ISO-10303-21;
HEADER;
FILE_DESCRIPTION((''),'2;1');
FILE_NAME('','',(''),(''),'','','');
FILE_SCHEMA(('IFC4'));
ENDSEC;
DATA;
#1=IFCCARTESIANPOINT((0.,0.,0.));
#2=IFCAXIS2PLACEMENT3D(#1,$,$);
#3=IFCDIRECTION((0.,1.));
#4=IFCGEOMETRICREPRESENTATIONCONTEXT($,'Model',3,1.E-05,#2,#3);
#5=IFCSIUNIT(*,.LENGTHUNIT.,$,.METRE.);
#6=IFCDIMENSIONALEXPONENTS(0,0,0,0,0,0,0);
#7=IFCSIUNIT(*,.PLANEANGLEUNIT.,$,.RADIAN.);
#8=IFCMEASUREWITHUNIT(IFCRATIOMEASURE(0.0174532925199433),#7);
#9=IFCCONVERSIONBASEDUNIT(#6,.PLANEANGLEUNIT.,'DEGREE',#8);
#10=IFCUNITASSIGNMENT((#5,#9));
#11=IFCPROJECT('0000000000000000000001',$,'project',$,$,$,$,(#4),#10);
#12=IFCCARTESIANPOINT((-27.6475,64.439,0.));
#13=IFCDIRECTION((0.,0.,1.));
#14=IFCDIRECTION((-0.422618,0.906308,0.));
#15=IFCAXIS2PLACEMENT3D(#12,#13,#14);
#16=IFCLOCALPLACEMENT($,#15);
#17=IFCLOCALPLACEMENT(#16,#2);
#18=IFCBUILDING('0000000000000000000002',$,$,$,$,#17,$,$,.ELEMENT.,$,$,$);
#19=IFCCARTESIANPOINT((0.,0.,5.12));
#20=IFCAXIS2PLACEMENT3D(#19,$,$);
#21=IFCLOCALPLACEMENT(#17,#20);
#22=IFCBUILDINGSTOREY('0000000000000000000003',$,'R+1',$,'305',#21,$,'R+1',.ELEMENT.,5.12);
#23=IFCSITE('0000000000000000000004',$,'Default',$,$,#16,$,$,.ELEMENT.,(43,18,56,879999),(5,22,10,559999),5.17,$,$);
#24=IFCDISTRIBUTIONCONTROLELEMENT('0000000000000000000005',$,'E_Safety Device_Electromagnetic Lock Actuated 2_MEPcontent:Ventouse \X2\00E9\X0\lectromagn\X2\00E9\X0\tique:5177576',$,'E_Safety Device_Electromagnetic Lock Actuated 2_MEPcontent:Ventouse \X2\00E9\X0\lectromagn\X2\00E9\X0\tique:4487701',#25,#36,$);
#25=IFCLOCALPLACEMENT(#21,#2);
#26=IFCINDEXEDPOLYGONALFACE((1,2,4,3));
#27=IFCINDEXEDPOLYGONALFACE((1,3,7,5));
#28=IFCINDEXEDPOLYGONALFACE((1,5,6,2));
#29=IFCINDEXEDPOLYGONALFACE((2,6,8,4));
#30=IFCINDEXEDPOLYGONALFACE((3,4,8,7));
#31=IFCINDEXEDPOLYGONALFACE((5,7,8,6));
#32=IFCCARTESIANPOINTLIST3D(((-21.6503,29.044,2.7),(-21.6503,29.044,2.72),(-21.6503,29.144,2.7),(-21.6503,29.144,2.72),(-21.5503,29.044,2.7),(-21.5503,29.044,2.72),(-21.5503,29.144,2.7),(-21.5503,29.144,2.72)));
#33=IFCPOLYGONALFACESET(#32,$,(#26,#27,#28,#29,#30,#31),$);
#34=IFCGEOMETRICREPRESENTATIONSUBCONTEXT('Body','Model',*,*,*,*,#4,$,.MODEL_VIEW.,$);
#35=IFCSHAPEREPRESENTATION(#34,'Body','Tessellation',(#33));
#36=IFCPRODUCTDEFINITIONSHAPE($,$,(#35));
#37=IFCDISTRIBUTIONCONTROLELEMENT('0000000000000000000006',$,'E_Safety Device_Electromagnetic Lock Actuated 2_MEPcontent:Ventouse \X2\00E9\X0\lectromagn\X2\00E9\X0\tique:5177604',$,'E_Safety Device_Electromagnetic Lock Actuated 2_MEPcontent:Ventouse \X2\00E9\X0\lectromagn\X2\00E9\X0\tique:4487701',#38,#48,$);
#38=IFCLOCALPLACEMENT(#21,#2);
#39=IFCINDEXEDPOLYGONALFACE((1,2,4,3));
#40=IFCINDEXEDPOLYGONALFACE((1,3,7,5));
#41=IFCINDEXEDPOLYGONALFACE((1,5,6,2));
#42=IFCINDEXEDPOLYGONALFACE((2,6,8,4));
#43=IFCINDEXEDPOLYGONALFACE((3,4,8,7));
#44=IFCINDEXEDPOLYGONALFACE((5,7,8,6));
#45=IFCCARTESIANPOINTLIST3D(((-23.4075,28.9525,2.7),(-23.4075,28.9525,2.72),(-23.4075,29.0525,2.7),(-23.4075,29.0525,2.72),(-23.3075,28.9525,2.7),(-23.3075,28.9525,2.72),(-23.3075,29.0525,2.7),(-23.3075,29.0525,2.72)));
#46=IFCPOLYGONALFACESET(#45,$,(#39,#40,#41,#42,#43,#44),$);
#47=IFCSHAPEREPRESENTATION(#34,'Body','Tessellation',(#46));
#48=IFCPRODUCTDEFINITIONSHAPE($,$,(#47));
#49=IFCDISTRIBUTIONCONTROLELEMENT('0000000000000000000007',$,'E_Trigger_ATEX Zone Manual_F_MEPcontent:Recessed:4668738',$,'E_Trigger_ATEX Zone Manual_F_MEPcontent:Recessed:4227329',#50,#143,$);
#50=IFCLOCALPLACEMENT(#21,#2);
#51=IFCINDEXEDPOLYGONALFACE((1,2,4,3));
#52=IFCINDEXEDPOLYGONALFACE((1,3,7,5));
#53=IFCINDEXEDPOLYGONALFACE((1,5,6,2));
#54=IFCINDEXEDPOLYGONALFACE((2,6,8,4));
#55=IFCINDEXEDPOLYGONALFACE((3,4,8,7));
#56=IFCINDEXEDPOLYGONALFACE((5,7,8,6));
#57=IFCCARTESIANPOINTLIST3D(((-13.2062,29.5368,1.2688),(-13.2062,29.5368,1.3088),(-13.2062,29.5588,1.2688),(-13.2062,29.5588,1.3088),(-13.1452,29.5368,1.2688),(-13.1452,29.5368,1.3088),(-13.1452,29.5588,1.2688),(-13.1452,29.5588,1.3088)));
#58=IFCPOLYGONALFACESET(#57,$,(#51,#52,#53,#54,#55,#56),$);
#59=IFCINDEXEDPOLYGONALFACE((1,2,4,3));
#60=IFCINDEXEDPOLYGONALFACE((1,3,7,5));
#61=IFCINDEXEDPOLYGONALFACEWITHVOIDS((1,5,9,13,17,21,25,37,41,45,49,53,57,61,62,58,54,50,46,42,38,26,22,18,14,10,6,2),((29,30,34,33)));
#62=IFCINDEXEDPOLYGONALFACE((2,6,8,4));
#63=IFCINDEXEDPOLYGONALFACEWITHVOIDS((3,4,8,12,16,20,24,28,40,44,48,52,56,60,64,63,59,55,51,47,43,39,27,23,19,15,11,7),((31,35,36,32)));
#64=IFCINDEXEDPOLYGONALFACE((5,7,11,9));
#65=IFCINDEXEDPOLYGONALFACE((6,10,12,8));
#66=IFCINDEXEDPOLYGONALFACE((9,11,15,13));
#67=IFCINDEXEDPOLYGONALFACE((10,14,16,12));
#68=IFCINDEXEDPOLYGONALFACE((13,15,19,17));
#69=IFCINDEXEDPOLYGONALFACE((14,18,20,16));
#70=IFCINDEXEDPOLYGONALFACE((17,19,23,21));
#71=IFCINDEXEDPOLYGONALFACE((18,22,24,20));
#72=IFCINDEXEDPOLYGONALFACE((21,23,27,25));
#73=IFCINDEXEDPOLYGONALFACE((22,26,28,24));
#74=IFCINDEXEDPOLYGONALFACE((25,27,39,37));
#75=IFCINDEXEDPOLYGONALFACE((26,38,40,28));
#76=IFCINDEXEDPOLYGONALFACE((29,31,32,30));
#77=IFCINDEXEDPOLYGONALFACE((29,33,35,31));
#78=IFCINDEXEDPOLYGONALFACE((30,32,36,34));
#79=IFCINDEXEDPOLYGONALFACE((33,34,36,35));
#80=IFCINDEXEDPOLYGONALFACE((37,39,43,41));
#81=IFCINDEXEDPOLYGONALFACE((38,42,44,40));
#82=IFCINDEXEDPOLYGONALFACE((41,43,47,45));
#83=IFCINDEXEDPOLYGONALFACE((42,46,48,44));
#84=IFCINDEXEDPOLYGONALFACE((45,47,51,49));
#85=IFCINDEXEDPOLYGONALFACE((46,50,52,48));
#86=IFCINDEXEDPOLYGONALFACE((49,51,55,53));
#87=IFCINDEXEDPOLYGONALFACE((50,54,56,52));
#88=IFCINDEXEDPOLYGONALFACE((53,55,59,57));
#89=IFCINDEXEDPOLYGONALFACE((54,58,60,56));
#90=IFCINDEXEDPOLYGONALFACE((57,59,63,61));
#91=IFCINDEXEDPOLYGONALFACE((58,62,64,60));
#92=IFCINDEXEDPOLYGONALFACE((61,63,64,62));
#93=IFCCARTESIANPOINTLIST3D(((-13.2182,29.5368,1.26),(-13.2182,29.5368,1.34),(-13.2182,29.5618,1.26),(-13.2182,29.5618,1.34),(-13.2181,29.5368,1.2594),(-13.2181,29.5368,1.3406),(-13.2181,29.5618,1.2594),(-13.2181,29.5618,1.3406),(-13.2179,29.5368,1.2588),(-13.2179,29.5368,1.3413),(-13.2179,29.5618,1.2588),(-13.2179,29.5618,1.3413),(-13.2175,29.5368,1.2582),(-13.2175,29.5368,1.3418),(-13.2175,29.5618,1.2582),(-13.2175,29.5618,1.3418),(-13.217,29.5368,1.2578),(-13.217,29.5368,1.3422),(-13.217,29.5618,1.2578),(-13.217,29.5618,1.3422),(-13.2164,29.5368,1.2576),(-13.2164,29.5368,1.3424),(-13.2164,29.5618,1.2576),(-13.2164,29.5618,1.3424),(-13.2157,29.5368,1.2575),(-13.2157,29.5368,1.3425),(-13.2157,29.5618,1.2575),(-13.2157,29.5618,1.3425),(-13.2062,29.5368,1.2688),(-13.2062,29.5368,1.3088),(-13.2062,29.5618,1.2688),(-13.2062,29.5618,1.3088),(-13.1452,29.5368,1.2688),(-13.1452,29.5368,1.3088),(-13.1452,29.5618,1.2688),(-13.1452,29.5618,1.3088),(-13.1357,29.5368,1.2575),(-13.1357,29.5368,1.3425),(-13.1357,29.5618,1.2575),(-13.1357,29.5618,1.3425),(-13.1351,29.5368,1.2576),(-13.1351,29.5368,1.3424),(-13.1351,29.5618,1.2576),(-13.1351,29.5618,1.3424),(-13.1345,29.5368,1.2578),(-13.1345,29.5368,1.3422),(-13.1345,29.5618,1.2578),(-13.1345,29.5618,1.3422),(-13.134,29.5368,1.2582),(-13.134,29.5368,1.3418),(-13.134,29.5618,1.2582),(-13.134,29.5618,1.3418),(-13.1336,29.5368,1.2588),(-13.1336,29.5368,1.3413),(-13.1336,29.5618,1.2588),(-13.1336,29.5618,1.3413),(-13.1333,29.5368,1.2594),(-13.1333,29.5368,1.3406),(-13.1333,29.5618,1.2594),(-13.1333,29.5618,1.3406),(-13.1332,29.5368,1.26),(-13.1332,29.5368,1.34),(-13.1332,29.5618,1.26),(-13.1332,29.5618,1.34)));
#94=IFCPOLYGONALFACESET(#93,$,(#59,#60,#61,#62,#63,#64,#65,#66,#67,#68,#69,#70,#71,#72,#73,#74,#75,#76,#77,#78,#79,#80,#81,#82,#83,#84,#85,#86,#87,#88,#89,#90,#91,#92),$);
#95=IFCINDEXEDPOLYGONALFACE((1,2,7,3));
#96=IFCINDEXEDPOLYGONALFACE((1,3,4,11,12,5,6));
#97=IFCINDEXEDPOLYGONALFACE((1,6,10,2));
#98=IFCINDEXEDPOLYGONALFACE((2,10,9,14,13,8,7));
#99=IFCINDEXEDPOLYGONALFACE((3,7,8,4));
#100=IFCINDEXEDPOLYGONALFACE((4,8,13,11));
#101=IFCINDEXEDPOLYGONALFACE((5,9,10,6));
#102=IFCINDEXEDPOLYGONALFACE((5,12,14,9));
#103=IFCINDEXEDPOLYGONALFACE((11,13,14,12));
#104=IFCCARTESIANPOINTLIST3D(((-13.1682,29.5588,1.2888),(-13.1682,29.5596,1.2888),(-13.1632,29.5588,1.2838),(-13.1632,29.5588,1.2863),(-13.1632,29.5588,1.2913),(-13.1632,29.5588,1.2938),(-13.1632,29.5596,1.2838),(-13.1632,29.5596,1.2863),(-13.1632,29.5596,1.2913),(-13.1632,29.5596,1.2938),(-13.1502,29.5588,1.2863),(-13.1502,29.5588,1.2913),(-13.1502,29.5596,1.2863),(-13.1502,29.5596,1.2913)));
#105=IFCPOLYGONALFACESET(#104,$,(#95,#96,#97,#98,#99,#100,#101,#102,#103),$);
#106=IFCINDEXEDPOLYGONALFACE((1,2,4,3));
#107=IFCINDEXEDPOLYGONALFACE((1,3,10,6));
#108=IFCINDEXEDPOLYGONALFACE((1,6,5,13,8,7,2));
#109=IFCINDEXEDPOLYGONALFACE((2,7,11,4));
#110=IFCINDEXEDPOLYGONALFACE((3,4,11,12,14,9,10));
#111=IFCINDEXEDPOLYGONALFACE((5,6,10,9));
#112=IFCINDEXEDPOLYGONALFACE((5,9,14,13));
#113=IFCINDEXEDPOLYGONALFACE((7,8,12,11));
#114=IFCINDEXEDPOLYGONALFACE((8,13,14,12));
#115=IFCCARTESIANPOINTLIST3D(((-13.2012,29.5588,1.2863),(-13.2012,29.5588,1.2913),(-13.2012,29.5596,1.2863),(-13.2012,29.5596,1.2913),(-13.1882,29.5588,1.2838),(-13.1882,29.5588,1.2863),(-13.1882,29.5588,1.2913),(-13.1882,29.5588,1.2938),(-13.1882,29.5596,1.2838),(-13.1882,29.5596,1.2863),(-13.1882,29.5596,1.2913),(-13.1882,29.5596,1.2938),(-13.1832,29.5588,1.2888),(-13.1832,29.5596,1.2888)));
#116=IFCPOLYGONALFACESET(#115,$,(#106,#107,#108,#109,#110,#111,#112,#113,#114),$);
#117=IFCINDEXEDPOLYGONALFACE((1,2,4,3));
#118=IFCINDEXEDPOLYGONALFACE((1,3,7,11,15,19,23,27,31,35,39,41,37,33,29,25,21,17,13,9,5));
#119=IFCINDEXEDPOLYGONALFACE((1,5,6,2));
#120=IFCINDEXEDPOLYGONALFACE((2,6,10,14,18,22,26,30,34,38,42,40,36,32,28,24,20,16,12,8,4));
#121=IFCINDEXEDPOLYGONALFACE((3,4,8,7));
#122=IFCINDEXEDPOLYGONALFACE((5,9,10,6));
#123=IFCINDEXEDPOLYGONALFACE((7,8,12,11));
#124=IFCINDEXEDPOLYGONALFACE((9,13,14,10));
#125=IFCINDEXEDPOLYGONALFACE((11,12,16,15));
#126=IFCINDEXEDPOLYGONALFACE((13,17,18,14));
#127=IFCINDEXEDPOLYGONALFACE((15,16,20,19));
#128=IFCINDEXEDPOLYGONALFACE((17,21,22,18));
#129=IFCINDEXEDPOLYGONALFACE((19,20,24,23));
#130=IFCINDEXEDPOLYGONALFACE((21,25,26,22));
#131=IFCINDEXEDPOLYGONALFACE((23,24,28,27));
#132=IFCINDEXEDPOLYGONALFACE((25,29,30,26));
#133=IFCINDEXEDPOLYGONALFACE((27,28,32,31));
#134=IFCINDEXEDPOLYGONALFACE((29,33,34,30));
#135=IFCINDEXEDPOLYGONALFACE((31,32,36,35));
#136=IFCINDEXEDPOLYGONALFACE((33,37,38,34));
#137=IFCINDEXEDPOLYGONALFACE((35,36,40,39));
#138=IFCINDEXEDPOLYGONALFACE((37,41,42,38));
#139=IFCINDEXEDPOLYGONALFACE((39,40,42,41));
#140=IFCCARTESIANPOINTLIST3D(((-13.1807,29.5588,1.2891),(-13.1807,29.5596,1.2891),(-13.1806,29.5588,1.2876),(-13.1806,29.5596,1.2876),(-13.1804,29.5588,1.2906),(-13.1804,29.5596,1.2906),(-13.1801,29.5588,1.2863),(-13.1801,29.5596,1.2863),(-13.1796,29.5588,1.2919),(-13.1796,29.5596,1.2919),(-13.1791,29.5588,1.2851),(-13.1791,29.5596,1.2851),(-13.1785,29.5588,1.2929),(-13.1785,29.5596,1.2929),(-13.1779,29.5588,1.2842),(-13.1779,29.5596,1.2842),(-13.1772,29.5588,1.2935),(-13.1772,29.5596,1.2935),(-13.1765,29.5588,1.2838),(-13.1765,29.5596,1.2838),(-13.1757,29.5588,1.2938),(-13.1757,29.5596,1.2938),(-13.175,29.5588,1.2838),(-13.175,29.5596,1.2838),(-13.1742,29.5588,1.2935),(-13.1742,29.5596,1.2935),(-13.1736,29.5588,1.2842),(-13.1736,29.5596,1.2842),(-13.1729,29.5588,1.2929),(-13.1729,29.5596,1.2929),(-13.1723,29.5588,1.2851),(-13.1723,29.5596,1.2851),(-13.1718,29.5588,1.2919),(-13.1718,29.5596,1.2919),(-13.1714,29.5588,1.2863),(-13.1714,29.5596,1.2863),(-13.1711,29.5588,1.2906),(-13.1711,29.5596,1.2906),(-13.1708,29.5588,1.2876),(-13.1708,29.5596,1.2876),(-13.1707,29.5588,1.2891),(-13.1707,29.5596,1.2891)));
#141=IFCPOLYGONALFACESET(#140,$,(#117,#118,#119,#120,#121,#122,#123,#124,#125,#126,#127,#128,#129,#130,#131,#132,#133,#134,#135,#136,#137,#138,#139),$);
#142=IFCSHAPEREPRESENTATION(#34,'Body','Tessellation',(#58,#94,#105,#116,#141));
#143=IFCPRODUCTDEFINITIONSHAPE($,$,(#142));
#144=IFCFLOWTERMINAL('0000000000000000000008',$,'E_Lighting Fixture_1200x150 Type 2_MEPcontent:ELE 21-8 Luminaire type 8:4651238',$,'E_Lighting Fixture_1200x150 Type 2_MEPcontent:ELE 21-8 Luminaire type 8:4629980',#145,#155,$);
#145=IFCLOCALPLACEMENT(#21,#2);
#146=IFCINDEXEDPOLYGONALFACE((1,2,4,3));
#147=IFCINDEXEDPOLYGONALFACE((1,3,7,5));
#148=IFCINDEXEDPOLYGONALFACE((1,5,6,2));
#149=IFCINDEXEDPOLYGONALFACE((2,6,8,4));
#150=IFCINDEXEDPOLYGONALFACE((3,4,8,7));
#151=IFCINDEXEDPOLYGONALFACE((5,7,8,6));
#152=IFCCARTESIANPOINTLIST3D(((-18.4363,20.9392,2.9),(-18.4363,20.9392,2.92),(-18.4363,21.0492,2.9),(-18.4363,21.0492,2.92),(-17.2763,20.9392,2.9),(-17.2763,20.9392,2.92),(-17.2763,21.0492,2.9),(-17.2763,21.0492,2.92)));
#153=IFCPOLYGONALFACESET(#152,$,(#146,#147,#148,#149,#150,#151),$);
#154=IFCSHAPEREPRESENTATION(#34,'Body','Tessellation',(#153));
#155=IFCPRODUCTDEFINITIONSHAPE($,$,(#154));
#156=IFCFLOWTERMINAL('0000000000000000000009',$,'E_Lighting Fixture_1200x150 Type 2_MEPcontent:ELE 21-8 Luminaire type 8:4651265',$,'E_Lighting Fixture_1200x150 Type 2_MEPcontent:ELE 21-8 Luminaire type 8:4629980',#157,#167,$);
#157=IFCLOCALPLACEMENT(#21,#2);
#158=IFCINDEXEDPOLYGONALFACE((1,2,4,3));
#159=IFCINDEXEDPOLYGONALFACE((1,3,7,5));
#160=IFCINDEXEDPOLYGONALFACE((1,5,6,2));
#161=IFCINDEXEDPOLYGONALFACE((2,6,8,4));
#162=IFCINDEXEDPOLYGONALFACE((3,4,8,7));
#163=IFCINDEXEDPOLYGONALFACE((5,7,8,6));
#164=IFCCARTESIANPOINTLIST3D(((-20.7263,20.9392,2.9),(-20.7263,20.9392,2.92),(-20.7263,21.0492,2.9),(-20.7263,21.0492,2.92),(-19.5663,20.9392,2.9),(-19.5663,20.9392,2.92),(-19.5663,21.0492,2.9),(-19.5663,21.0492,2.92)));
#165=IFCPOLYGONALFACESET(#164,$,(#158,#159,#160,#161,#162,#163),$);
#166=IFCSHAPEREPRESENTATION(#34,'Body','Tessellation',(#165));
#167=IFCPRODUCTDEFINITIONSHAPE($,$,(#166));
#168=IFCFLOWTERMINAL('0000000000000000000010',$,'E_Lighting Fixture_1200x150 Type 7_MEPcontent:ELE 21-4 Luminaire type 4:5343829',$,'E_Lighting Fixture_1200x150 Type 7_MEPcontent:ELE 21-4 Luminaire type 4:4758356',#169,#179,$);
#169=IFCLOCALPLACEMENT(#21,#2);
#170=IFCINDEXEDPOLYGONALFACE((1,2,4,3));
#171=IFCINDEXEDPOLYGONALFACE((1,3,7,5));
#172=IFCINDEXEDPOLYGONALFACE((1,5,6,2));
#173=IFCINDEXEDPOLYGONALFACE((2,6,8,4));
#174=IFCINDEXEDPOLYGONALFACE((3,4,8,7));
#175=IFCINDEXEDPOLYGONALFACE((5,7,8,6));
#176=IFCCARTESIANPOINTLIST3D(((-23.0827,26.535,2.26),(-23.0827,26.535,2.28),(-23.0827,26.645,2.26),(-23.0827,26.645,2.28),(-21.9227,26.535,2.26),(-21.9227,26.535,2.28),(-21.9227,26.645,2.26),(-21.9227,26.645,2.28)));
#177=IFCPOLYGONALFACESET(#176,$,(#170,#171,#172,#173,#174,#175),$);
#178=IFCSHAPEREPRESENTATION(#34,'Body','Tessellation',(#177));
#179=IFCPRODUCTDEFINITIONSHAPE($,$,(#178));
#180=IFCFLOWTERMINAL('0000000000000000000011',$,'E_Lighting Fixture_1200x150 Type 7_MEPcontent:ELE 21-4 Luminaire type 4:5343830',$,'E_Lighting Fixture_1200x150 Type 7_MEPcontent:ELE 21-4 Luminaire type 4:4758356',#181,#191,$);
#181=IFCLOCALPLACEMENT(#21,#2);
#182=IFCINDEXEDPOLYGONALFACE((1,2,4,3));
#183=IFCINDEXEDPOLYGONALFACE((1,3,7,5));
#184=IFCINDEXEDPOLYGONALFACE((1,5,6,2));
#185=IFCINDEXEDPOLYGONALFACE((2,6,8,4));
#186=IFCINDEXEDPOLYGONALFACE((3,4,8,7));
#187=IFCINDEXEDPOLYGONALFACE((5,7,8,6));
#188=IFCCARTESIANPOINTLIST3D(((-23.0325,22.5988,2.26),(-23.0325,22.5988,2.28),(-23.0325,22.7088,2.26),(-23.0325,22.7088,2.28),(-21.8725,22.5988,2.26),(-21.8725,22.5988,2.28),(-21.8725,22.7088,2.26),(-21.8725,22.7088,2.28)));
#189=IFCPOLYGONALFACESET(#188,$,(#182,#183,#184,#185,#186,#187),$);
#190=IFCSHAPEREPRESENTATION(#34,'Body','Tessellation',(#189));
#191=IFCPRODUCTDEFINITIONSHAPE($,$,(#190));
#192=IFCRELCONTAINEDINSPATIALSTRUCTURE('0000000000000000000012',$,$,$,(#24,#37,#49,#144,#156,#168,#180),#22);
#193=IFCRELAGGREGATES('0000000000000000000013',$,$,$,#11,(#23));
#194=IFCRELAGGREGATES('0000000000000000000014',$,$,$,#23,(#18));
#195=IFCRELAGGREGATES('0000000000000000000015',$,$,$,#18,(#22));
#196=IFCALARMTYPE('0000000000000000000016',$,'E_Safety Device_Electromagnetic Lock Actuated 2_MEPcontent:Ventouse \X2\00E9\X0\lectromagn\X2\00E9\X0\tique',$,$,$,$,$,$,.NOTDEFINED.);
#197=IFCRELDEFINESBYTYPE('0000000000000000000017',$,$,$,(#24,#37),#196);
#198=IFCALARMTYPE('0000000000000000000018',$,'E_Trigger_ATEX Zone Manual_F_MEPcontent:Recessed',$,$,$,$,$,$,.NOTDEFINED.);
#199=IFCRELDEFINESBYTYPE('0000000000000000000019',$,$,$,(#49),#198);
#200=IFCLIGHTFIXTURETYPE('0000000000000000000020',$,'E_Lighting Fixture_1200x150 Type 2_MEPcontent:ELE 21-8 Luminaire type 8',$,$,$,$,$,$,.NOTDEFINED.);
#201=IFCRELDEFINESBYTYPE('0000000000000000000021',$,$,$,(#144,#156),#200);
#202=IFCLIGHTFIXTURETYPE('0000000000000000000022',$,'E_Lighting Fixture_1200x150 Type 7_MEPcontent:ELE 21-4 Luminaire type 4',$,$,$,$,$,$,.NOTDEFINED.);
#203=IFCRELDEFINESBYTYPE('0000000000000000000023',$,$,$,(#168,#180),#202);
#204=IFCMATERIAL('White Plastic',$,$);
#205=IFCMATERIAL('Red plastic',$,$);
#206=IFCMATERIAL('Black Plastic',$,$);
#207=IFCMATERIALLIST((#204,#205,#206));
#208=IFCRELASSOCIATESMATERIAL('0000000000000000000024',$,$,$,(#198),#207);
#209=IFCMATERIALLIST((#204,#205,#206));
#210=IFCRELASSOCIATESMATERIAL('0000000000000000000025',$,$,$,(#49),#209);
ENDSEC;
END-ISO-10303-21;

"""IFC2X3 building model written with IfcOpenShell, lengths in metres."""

from ifc_helpers import new_model, entity, si_unit, converted_unit, direction, frame, frame_2d, origin, origin_2d_with_axis, place, context, subcontext, project, spatial, polyline, circle_curve, parameter, trimmed, segment, composite_curve, rectangle, circle, outline, extrude, source, transform, mapped, material, material_list, type_object, type_shapes, element, save


model = new_model("IFC2X3")

# Units and contexts
model_context = context("Model", 3, precision=1e-05, world=origin(), true_north=direction((0.0, 1.0)))
body_context = subcontext(model_context, "Body", "Model", "MODEL_VIEW")
ifc_project = project(units=[si_unit("LENGTHUNIT", "METRE"), converted_unit("PLANEANGLEUNIT", "DEGREE", entity("IfcRatioMeasure", 0.0174532925199433), si_unit("PLANEANGLEUNIT", "RADIAN"), dimensions=[0, 0, 0, 0, 0, 0, 0])], contexts=[model_context])

# Site, building, storey
site_placement = place(None, frame((-27.6475, 64.439, 0.0), z_axis=(0.0, 0.0, 1.0), x_axis=(-0.422618, 0.906308, 0.0)))
site = spatial("IfcSite", under=ifc_project, at=site_placement, Name="Default", CompositionType="ELEMENT", RefLatitude=(43, 18, 56, 879999), RefLongitude=(5, 22, 10, 559999), RefElevation=5.17)
building_placement = place(site_placement, origin())
building = spatial("IfcBuilding", under=site, at=building_placement, CompositionType="ELEMENT")
storey_placement = place(building_placement, frame((0.0, 0.0, 5.12)))
storey = spatial("IfcBuildingStorey", under=building, at=storey_placement, Name="R+1", ObjectType="305", LongName="R+1", CompositionType="ELEMENT", Elevation=5.12)

# Distribution control elements
alarm_type_1 = type_object("IfcAlarmType", Name="E_Safety Device_Electromagnetic Lock Actuated 2_MEPcontent:Ventouse électromagnétique", PredefinedType="NOTDEFINED")
shared_shape_1 = source(origin(), body_context, "Body", "SweptSolid", [
    extrude(rectangle(XDim=0.1, YDim=0.1, at=origin_2d_with_axis()), frame((0.0, 0.0, 0.0), z_axis=(0.0, 0.0, 1.0), x_axis=(0.0, -1.0, 0.0)), (0.0, 0.0, 1.0), 0.02),
])
type_shapes(alarm_type_1, [shared_shape_1])
for number, where, z_axis, x_axis, name in (
    (1, (-21.6003, 29.094, 2.7), (0.0, 0.0, 1.0), (0.0, 1.0, 0.0), "E_Safety Device_Electromagnetic Lock Actuated 2_MEPcontent:Ventouse électromagnétique:5177576"),
    (2, (-23.3575, 29.0025, 2.7), (0.0, 0.0, 1.0), (0.0, -1.0, 0.0), "E_Safety Device_Electromagnetic Lock Actuated 2_MEPcontent:Ventouse électromagnétique:5177604"),
):
    element("IfcDistributionControlElement", number, at=place(storey_placement, frame(where, z_axis=z_axis, x_axis=x_axis)), inside=storey, type_object=alarm_type_1, Name=name, ObjectType="E_Safety Device_Electromagnetic Lock Actuated 2_MEPcontent:Ventouse électromagnétique:4487701", context=body_context, shape_type="MappedRepresentation", body=[
        mapped(shared_shape_1, transform((0.0, 0.0, 0.0), scale=1.0)),
    ])
ifc_material_1 = material(Name="White Plastic")
ifc_material_2 = material(Name="Red plastic")
ifc_material_3 = material(Name="Black Plastic")
ifc_material_list_1 = material_list([ifc_material_1, ifc_material_2, ifc_material_3])
ifc_material_list_2 = material_list([ifc_material_1, ifc_material_2, ifc_material_3])
alarm_type_2 = type_object("IfcAlarmType", Name="E_Trigger_ATEX Zone Manual_F_MEPcontent:Recessed", PredefinedType="NOTDEFINED", material=ifc_material_list_2)
shared_shape_2 = source(origin(), body_context, "Body", "SweptSolid", [
    extrude(rectangle(XDim=0.061, YDim=0.04, at=origin_2d_with_axis()), frame((0.0, -0.0112, 0.0), z_axis=(0.0, 0.0, 1.0), x_axis=(-1.0, 0.0, 0.0)), (0.0, 0.0, 1.0), 0.022),
    extrude(outline(composite_curve([segment(polyline([(-0.04, -0.0425), (0.04, -0.0425)]), True, "CONTINUOUS"), segment(trimmed(circle_curve(frame_2d((0.04, -0.04), x_axis=(-1.0, 0.0)), 0.0025), [parameter(90.0)], [parameter(180.0)], True, "PARAMETER"), True, "CONTINUOUS"), segment(polyline([(0.0425, -0.04), (0.0425, 0.04)]), True, "CONTINUOUS"), segment(trimmed(circle_curve(frame_2d((0.04, 0.04), x_axis=(-1.0, 0.0)), 0.0025), [parameter(180.0)], [parameter(270.0)], True, "PARAMETER"), True, "CONTINUOUS"), segment(polyline([(0.04, 0.0425), (-0.04, 0.0425)]), True, "CONTINUOUS"), segment(trimmed(circle_curve(frame_2d((-0.04, 0.04), x_axis=(-1.0, 0.0)), 0.0025), [parameter(270.0)], [parameter(0.0)], True, "PARAMETER"), True, "CONTINUOUS"), segment(polyline([(-0.0425, 0.04), (-0.0425, -0.04)]), True, "CONTINUOUS"), segment(trimmed(circle_curve(frame_2d((-0.04, -0.04), x_axis=(-1.0, 0.0)), 0.0025), [parameter(360.0)], [parameter(90.0)], True, "PARAMETER"), True, "CONTINUOUS")], self_intersect=False), holes=[polyline([(-0.0305, -0.0088), (-0.0305, 0.0312), (0.0305, 0.0312), (0.0305, -0.0088), (-0.0305, -0.0088)])]), frame((0.0, 0.0, 0.0), z_axis=(0.0, 0.0, 1.0), x_axis=(-1.0, 0.0, 0.0)), (0.0, 0.0, 1.0), 0.025),
    extrude(outline(polyline([(-0.01, 0.0025), (-0.01, -0.0025), (0.003, -0.0025), (0.003, -0.005), (0.008, 0.0), (0.003, 0.005), (0.003, 0.0025), (-0.01, 0.0025)])), frame((-0.0155, -0.0112, 0.022), z_axis=(0.0, 0.0, -1.0), x_axis=(1.0, 0.0, 0.0)), (0.0, 0.0, -1.0), 0.0008),
    extrude(outline(polyline([(-0.0014, -0.0057), (0.0057, -0.0057), (0.0057, 0.0014), (0.0039, -0.0004), (-0.0053, 0.0088), (-0.0088, 0.0053), (0.0004, -0.0039), (-0.0014, -0.0057)])), frame((0.0155, -0.0112, 0.022), z_axis=(0.0, 0.0, 1.0), x_axis=(-0.707107, -0.707107, 0.0)), (0.0, 0.0, 1.0), 0.0008),
    extrude(circle(Radius=0.005, at=frame_2d((0.0, 0.0), x_axis=(1.0, 0.0))), frame((0.0, -0.0112, 0.022), z_axis=(0.0, 0.0, 1.0), x_axis=(0.0, 1.0, 0.0)), (0.0, 0.0, 1.0), 0.0008),
])
type_shapes(alarm_type_2, [shared_shape_2])
distribution_control_element_placement = place(storey_placement, frame((-13.1757, 29.5368, 1.3), z_axis=(0.0, 1.0, 0.0), x_axis=(-1.0, 0.0, 0.0)))
element("IfcDistributionControlElement", 3, at=distribution_control_element_placement, inside=storey, type_object=alarm_type_2, material=ifc_material_list_1, Name="E_Trigger_ATEX Zone Manual_F_MEPcontent:Recessed:4668738", ObjectType="E_Trigger_ATEX Zone Manual_F_MEPcontent:Recessed:4227329", context=body_context, shape_type="MappedRepresentation", body=[
    mapped(shared_shape_2, transform((0.0, 0.0, 0.0), scale=1.0)),
])

# Flow terminals
light_fixture_type_1 = type_object("IfcLightFixtureType", Name="E_Lighting Fixture_1200x150 Type 2_MEPcontent:ELE 21-8 Luminaire type 8", PredefinedType="NOTDEFINED")
shared_shape_3 = source(origin(), body_context, "Body", "SweptSolid", [
    extrude(rectangle(XDim=0.11, YDim=1.16, at=origin_2d_with_axis()), frame((0.0, 0.0, 0.0), z_axis=(0.0, 0.0, 1.0), x_axis=(0.0, -1.0, 0.0)), (0.0, 0.0, 1.0), 0.02),
])
type_shapes(light_fixture_type_1, [shared_shape_3])
flow_terminal_1_placement = place(storey_placement, frame((-17.8563, 20.9942, 2.9), z_axis=(0.0, 0.0, 1.0), x_axis=(-1.0, 0.0, 0.0)))
element("IfcFlowTerminal", 4, at=flow_terminal_1_placement, inside=storey, type_object=light_fixture_type_1, Name="E_Lighting Fixture_1200x150 Type 2_MEPcontent:ELE 21-8 Luminaire type 8:4651238", ObjectType="E_Lighting Fixture_1200x150 Type 2_MEPcontent:ELE 21-8 Luminaire type 8:4629980", context=body_context, shape_type="MappedRepresentation", body=[
    mapped(shared_shape_3, transform((0.0, 0.0, 0.0), scale=1.0)),
])
flow_terminal_2_placement = place(storey_placement, frame((-20.1463, 20.9942, 2.9)))
element("IfcFlowTerminal", 5, at=flow_terminal_2_placement, inside=storey, type_object=light_fixture_type_1, Name="E_Lighting Fixture_1200x150 Type 2_MEPcontent:ELE 21-8 Luminaire type 8:4651265", ObjectType="E_Lighting Fixture_1200x150 Type 2_MEPcontent:ELE 21-8 Luminaire type 8:4629980", context=body_context, shape_type="MappedRepresentation", body=[
    mapped(shared_shape_3, transform((0.0, 0.0, 0.0), scale=1.0)),
])
light_fixture_type_2 = type_object("IfcLightFixtureType", Name="E_Lighting Fixture_1200x150 Type 7_MEPcontent:ELE 21-4 Luminaire type 4", PredefinedType="NOTDEFINED")
shared_shape_4 = source(origin(), body_context, "Body", "SweptSolid", [
    extrude(rectangle(XDim=0.11, YDim=1.16, at=origin_2d_with_axis()), frame((0.0, 0.0, 0.0), z_axis=(0.0, 0.0, 1.0), x_axis=(0.0, -1.0, 0.0)), (0.0, 0.0, 1.0), 0.02),
])
type_shapes(light_fixture_type_2, [shared_shape_4])
for number, where, name in (
    (6, (-22.5027, 26.59, 2.26), "E_Lighting Fixture_1200x150 Type 7_MEPcontent:ELE 21-4 Luminaire type 4:5343829"),
    (7, (-22.4525, 22.6538, 2.26), "E_Lighting Fixture_1200x150 Type 7_MEPcontent:ELE 21-4 Luminaire type 4:5343830"),
):
    element("IfcFlowTerminal", number, at=place(storey_placement, frame(where)), inside=storey, type_object=light_fixture_type_2, Name=name, ObjectType="E_Lighting Fixture_1200x150 Type 7_MEPcontent:ELE 21-4 Luminaire type 4:4758356", context=body_context, shape_type="MappedRepresentation", body=[
        mapped(shared_shape_4, transform((0.0, 0.0, 0.0), scale=1.0)),
    ])

save(model, "model.ifc")
